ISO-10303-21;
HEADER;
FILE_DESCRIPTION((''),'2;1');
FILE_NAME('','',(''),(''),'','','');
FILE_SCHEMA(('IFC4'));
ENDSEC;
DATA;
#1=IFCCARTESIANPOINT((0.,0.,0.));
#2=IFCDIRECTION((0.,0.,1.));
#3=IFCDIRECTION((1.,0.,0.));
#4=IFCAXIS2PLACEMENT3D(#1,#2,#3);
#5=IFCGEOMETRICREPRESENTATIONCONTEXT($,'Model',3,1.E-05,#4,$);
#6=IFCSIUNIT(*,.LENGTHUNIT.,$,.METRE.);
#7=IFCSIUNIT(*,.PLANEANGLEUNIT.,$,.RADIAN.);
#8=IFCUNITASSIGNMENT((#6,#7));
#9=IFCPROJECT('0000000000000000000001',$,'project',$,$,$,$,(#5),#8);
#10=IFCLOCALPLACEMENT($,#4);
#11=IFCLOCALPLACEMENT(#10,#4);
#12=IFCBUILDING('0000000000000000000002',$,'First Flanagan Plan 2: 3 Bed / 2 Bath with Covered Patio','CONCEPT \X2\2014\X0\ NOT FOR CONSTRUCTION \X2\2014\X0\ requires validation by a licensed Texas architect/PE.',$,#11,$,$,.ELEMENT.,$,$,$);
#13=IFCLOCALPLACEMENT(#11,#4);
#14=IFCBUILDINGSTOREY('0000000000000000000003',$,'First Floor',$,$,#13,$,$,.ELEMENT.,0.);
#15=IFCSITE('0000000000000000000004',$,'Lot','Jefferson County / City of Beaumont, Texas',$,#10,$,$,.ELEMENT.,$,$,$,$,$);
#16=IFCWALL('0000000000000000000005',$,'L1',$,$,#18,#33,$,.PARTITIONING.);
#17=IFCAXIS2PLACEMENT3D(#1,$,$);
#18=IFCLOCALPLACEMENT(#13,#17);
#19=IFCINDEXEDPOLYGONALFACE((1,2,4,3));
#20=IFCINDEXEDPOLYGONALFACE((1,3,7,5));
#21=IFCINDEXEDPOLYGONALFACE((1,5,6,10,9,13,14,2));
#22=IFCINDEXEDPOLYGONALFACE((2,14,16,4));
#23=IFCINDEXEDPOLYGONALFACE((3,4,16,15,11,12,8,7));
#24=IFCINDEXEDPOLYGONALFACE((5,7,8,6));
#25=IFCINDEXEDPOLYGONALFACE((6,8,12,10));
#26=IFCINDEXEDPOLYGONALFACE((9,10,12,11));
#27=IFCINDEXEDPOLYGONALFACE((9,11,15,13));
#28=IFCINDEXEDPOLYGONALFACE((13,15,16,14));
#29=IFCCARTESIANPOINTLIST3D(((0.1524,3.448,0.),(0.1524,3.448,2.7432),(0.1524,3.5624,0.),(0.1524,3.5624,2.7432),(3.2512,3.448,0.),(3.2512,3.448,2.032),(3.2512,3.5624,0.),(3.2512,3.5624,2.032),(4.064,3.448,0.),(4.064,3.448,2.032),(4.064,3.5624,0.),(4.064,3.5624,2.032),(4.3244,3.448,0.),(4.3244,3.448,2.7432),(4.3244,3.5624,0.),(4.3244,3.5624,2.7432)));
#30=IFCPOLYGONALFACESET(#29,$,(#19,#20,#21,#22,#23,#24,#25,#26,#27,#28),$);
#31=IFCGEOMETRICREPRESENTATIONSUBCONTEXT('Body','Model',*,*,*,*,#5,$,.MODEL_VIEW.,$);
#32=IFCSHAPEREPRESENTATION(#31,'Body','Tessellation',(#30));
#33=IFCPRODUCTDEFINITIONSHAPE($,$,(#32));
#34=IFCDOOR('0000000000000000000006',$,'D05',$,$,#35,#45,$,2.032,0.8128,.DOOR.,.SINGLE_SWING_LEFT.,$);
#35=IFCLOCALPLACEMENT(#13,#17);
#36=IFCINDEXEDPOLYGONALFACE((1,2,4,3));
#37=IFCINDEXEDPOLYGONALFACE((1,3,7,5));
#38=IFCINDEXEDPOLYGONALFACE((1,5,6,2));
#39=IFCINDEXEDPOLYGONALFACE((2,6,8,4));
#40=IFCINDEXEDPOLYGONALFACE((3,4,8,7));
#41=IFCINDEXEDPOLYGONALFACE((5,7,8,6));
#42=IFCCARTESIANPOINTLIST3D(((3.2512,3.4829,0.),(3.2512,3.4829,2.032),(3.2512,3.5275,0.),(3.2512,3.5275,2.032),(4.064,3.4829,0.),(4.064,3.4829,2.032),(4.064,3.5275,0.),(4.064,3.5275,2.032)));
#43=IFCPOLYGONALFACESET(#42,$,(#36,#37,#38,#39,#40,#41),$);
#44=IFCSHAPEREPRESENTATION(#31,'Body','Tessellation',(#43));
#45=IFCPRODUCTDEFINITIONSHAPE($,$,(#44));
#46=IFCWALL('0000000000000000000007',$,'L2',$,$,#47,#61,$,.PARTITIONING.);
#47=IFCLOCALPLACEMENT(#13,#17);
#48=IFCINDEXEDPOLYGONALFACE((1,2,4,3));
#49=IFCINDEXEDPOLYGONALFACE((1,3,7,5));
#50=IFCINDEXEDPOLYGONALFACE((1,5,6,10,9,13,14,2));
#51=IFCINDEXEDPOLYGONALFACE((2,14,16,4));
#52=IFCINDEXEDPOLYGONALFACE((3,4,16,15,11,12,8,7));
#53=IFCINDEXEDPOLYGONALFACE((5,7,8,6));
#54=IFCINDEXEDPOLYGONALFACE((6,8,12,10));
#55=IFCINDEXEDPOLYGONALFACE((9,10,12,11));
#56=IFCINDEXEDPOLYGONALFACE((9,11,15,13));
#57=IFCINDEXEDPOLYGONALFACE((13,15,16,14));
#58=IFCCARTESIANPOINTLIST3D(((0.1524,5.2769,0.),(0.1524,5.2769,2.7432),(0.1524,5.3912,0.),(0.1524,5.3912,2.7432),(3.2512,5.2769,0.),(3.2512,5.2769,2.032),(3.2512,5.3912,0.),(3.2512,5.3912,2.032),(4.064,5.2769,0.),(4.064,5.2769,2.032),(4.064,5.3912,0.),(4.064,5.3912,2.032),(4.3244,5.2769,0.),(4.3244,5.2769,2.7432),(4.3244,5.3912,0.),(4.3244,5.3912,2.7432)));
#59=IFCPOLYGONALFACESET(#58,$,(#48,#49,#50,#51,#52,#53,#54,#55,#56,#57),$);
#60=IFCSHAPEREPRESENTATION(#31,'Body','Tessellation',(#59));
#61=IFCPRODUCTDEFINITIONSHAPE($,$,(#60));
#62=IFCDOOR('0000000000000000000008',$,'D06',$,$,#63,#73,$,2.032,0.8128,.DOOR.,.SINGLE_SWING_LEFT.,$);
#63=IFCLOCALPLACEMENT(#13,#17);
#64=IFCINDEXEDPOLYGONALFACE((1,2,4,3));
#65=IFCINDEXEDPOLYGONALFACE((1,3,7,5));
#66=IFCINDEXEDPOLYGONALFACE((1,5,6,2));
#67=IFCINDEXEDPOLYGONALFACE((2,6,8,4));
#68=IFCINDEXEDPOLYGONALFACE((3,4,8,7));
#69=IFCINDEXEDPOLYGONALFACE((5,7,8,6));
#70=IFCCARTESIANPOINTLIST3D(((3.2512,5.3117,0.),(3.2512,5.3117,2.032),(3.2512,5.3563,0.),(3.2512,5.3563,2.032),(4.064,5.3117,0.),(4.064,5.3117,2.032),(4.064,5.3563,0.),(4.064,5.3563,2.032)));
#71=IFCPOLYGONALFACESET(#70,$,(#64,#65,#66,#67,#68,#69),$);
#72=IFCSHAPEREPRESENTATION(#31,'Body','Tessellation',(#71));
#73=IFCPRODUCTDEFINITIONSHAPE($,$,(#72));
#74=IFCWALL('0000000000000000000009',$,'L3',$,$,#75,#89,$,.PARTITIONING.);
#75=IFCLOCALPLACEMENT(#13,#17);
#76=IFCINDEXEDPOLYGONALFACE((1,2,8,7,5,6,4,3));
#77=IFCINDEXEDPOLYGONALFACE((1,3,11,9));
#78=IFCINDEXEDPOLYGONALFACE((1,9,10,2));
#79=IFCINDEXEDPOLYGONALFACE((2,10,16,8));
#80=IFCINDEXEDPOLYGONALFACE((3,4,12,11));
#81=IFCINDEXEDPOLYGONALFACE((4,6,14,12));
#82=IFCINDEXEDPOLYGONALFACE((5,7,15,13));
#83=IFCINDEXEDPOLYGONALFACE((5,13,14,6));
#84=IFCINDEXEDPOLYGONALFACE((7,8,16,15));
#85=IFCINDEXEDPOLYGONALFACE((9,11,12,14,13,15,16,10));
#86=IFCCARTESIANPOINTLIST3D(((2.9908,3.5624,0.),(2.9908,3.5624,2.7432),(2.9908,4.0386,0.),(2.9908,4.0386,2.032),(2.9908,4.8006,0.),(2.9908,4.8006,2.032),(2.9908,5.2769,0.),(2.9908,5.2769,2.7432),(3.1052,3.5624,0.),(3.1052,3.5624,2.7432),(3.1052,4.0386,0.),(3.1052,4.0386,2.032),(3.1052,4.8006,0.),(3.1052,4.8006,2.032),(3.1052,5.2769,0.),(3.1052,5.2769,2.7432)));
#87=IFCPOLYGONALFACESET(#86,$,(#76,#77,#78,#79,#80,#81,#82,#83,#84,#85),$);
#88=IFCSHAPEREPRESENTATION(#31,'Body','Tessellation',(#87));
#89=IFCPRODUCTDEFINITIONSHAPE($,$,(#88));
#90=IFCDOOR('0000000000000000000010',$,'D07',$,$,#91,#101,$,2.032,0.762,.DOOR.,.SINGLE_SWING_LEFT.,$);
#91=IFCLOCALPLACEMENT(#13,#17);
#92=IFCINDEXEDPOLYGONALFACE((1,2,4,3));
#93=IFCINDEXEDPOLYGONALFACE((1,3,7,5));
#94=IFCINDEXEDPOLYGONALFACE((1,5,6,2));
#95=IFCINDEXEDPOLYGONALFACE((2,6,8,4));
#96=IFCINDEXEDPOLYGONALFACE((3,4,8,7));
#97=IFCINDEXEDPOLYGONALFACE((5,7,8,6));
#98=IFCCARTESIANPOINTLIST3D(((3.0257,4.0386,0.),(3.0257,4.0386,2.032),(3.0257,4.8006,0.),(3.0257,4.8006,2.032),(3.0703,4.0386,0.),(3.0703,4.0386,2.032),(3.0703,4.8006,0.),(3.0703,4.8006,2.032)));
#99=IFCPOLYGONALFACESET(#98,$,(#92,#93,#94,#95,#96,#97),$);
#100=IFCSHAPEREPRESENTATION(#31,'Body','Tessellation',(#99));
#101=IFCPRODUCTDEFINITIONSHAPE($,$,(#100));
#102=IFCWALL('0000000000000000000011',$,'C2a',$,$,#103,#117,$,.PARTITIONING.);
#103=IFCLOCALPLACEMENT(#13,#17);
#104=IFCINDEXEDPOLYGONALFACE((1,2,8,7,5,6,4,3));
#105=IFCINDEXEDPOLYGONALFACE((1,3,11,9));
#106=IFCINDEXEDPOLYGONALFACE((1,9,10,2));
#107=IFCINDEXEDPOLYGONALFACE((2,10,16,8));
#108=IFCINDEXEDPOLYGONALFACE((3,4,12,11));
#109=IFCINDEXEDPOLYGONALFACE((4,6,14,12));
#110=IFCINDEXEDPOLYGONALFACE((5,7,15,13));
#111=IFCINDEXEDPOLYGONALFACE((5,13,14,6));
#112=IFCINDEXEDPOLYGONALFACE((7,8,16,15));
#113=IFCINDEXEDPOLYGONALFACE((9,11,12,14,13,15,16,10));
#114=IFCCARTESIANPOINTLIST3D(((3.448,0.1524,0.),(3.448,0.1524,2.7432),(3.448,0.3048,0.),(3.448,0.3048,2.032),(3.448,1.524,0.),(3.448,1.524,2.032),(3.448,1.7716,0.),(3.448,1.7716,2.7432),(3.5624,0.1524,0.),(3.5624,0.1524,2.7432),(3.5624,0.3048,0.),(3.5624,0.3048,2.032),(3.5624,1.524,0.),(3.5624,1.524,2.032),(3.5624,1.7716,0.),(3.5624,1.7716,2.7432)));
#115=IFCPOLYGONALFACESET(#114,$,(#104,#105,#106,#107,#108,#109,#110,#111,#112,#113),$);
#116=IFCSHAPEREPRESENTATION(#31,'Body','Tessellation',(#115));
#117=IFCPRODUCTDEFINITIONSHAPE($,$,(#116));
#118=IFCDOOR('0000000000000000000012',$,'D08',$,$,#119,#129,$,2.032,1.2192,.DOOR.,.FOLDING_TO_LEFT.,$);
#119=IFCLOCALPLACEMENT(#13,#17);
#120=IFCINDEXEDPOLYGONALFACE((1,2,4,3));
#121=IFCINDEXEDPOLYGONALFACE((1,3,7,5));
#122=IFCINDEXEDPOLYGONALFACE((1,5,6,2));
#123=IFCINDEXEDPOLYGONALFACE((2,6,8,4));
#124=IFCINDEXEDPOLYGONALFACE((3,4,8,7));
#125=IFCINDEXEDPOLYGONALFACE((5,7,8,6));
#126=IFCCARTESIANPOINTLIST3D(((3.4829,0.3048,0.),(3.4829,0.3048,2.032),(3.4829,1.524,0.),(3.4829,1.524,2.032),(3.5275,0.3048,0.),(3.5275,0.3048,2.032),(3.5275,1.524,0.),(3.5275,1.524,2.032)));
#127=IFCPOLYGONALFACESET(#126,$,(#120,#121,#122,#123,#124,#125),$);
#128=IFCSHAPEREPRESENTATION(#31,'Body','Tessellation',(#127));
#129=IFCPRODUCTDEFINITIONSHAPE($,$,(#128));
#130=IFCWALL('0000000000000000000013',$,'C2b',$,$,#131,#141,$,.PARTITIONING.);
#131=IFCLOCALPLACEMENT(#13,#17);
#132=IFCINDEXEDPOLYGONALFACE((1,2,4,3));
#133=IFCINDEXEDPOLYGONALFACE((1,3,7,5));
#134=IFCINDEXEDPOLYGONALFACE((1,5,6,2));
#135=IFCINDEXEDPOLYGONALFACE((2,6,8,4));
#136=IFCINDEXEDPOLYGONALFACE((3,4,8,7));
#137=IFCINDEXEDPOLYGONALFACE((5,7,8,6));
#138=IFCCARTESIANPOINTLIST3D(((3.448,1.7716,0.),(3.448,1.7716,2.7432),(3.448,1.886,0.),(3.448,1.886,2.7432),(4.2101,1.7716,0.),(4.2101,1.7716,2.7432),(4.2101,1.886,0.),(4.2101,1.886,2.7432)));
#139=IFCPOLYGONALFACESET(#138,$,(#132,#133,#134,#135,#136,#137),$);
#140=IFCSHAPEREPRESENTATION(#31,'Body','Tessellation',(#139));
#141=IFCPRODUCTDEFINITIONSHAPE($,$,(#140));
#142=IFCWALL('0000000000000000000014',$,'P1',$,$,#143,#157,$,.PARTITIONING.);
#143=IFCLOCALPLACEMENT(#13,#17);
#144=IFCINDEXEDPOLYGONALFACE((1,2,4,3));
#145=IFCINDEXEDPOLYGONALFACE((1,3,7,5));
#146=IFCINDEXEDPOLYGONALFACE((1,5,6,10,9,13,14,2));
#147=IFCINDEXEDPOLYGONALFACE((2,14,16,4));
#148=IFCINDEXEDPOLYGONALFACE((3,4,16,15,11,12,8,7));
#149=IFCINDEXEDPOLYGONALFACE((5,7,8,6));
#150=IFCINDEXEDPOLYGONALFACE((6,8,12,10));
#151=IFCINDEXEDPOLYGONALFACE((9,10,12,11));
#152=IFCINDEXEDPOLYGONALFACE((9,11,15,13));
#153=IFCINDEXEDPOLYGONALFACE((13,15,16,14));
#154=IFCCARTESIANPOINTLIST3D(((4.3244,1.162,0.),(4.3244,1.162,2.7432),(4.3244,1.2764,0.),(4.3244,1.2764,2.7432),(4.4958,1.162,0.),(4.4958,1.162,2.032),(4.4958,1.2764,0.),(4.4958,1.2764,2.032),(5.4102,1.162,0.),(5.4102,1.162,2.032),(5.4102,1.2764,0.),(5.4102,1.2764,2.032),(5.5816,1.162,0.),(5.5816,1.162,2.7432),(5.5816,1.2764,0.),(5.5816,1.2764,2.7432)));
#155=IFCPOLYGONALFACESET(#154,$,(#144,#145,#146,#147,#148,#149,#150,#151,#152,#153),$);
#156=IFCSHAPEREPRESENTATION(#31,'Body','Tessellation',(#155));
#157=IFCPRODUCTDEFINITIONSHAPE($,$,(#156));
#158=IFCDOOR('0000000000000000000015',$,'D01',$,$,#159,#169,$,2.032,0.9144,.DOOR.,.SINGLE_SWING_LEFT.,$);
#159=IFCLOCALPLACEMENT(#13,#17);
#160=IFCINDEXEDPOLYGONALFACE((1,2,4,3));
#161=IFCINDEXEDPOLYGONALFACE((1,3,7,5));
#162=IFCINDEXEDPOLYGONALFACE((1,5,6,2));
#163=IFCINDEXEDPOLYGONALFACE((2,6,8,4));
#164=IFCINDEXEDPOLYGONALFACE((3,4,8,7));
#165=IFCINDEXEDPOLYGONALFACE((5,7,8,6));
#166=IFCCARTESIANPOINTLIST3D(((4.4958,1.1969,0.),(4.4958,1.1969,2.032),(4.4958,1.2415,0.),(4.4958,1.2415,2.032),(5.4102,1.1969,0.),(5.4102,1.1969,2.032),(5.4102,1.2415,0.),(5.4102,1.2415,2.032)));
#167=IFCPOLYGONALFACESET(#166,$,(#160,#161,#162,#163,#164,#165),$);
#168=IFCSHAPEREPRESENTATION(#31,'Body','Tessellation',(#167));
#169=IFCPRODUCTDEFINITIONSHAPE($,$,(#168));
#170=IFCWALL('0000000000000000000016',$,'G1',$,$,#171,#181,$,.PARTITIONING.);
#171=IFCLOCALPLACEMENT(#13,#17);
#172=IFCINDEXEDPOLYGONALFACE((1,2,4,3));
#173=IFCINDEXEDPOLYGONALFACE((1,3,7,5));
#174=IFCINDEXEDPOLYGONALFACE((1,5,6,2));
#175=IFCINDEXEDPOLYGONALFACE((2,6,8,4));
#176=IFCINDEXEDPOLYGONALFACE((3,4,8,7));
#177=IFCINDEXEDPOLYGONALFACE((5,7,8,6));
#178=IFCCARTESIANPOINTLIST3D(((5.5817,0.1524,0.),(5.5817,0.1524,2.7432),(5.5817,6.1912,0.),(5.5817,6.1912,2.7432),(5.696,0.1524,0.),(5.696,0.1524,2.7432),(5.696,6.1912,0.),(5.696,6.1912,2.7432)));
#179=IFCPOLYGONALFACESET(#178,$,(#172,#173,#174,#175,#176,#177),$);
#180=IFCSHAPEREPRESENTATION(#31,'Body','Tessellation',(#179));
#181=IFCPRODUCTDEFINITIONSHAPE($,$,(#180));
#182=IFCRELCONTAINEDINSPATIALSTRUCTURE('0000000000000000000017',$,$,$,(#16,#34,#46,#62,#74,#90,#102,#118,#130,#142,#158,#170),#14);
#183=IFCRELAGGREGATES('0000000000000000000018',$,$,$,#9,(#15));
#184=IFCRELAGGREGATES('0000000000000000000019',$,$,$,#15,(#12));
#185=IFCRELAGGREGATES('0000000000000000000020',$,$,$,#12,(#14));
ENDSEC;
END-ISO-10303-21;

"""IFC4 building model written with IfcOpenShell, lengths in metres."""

from ifc_helpers import new_model, si_unit, frame, frame_2d, origin_with_axes, place, context, subcontext, project, spatial, rectangle, extrude, element, fill, save


model = new_model("IFC4")

# Units and contexts
model_context = context("Model", 3, precision=1e-05, world=origin_with_axes())
body_context = subcontext(model_context, "Body", "Model", "MODEL_VIEW")
ifc_project = project(units=[si_unit("LENGTHUNIT", "METRE"), si_unit("PLANEANGLEUNIT", "RADIAN")], contexts=[model_context])

# Site, building, storey
site_placement = place(None, origin_with_axes())
site = spatial("IfcSite", under=ifc_project, at=site_placement, Name="Lot", Description="Jefferson County / City of Beaumont, Texas", CompositionType="ELEMENT")
building_placement = place(site_placement, origin_with_axes())
building = spatial("IfcBuilding", under=site, at=building_placement, Name="First Flanagan Plan 2: 3 Bed / 2 Bath with Covered Patio", Description="CONCEPT — NOT FOR CONSTRUCTION — requires validation by a licensed Texas architect/PE.", CompositionType="ELEMENT")
storey_placement = place(building_placement, origin_with_axes())
storey = spatial("IfcBuildingStorey", under=building, at=storey_placement, Name="First Floor", CompositionType="ELEMENT", Elevation=0.0)

# Walls, openings, doors
wall_1_placement = place(storey_placement, frame((0.1524, 3.5052, 0.0), z_axis=(0.0, 0.0, 1.0), x_axis=(1.0, 0.0, 0.0)))
wall_1 = element("IfcWall", 1, at=wall_1_placement, inside=storey, Name="L1", PredefinedType="PARTITIONING", context=body_context, shape_type="SweptSolid", body=[
    extrude(rectangle(XDim=4.1719, YDim=0.1143, at=frame_2d((2.086, 0.0), x_axis=(1.0, 0.0))), origin_with_axes(), (0.0, 0.0, 1.0), 2.7432),
])
opening_1_placement = place(wall_1_placement, frame((3.0988, 0.0, 0.0), z_axis=(0.0, 0.0, 1.0), x_axis=(1.0, 0.0, 0.0)))
opening_1 = element("IfcOpeningElement", 2, at=opening_1_placement, cuts=wall_1, PredefinedType="OPENING", context=body_context, shape_type="SweptSolid", body=[
    extrude(rectangle(XDim=0.8128, YDim=0.1448, at=frame_2d((0.4064, 0.0), x_axis=(1.0, 0.0))), origin_with_axes(), (0.0, 0.0, 1.0), 2.032),
])
door_1_placement = place(opening_1_placement, origin_with_axes())
door_1 = element("IfcDoor", 3, at=door_1_placement, inside=storey, Name="D05", OperationType="SINGLE_SWING_LEFT", OverallHeight=2.032, OverallWidth=0.8128, PredefinedType="DOOR", context=body_context, shape_type="SweptSolid", body=[
    extrude(rectangle(XDim=0.8128, YDim=0.0445, at=frame_2d((0.4064, 0.0), x_axis=(1.0, 0.0))), origin_with_axes(), (0.0, 0.0, 1.0), 2.032),
])
fill(opening_1, door_1)
wall_2_placement = place(storey_placement, frame((0.1524, 5.334, 0.0), z_axis=(0.0, 0.0, 1.0), x_axis=(1.0, 0.0, 0.0)))
wall_2 = element("IfcWall", 4, at=wall_2_placement, inside=storey, Name="L2", PredefinedType="PARTITIONING", context=body_context, shape_type="SweptSolid", body=[
    extrude(rectangle(XDim=4.1719, YDim=0.1143, at=frame_2d((2.086, 0.0), x_axis=(1.0, 0.0))), origin_with_axes(), (0.0, 0.0, 1.0), 2.7432),
])
opening_2_placement = place(wall_2_placement, frame((3.0988, 0.0, 0.0), z_axis=(0.0, 0.0, 1.0), x_axis=(1.0, 0.0, 0.0)))
opening_2 = element("IfcOpeningElement", 5, at=opening_2_placement, cuts=wall_2, PredefinedType="OPENING", context=body_context, shape_type="SweptSolid", body=[
    extrude(rectangle(XDim=0.8128, YDim=0.1448, at=frame_2d((0.4064, 0.0), x_axis=(1.0, 0.0))), origin_with_axes(), (0.0, 0.0, 1.0), 2.032),
])
door_2_placement = place(opening_2_placement, origin_with_axes())
door_2 = element("IfcDoor", 6, at=door_2_placement, inside=storey, Name="D06", OperationType="SINGLE_SWING_LEFT", OverallHeight=2.032, OverallWidth=0.8128, PredefinedType="DOOR", context=body_context, shape_type="SweptSolid", body=[
    extrude(rectangle(XDim=0.8128, YDim=0.0445, at=frame_2d((0.4064, 0.0), x_axis=(1.0, 0.0))), origin_with_axes(), (0.0, 0.0, 1.0), 2.032),
])
fill(opening_2, door_2)
wall_3_placement = place(storey_placement, frame((3.048, 3.5624, 0.0), z_axis=(0.0, 0.0, 1.0), x_axis=(0.0, 1.0, 0.0)))
wall_3 = element("IfcWall", 7, at=wall_3_placement, inside=storey, Name="L3", PredefinedType="PARTITIONING", context=body_context, shape_type="SweptSolid", body=[
    extrude(rectangle(XDim=1.7145, YDim=0.1143, at=frame_2d((0.8573, 0.0), x_axis=(1.0, 0.0))), origin_with_axes(), (0.0, 0.0, 1.0), 2.7432),
])
opening_3_placement = place(wall_3_placement, frame((0.4763, 0.0, 0.0), z_axis=(0.0, 0.0, 1.0), x_axis=(1.0, 0.0, 0.0)))
opening_3 = element("IfcOpeningElement", 8, at=opening_3_placement, cuts=wall_3, PredefinedType="OPENING", context=body_context, shape_type="SweptSolid", body=[
    extrude(rectangle(XDim=0.762, YDim=0.1448, at=frame_2d((0.381, 0.0), x_axis=(1.0, 0.0))), origin_with_axes(), (0.0, 0.0, 1.0), 2.032),
])
door_3_placement = place(opening_3_placement, origin_with_axes())
door_3 = element("IfcDoor", 9, at=door_3_placement, inside=storey, Name="D07", OperationType="SINGLE_SWING_LEFT", OverallHeight=2.032, OverallWidth=0.762, PredefinedType="DOOR", context=body_context, shape_type="SweptSolid", body=[
    extrude(rectangle(XDim=0.762, YDim=0.0445, at=frame_2d((0.381, 0.0), x_axis=(1.0, 0.0))), origin_with_axes(), (0.0, 0.0, 1.0), 2.032),
])
fill(opening_3, door_3)
wall_4_placement = place(storey_placement, frame((3.5052, 0.1524, 0.0), z_axis=(0.0, 0.0, 1.0), x_axis=(0.0, 1.0, 0.0)))
wall_4 = element("IfcWall", 10, at=wall_4_placement, inside=storey, Name="C2a", PredefinedType="PARTITIONING", context=body_context, shape_type="SweptSolid", body=[
    extrude(rectangle(XDim=1.6193, YDim=0.1143, at=frame_2d((0.8096, 0.0), x_axis=(1.0, 0.0))), origin_with_axes(), (0.0, 0.0, 1.0), 2.7432),
])
opening_4_placement = place(wall_4_placement, frame((0.1524, 0.0, 0.0), z_axis=(0.0, 0.0, 1.0), x_axis=(1.0, 0.0, 0.0)))
opening_4 = element("IfcOpeningElement", 11, at=opening_4_placement, cuts=wall_4, PredefinedType="OPENING", context=body_context, shape_type="SweptSolid", body=[
    extrude(rectangle(XDim=1.2192, YDim=0.1448, at=frame_2d((0.6096, 0.0), x_axis=(1.0, 0.0))), origin_with_axes(), (0.0, 0.0, 1.0), 2.032),
])
door_4_placement = place(opening_4_placement, origin_with_axes())
door_4 = element("IfcDoor", 12, at=door_4_placement, inside=storey, Name="D08", OperationType="FOLDING_TO_LEFT", OverallHeight=2.032, OverallWidth=1.2192, PredefinedType="DOOR", context=body_context, shape_type="SweptSolid", body=[
    extrude(rectangle(XDim=1.2192, YDim=0.0445, at=frame_2d((0.6096, 0.0), x_axis=(1.0, 0.0))), origin_with_axes(), (0.0, 0.0, 1.0), 2.032),
])
fill(opening_4, door_4)

# Wall
wall_5_placement = place(storey_placement, frame((3.4481, 1.8288, 0.0), z_axis=(0.0, 0.0, 1.0), x_axis=(1.0, 0.0, 0.0)))
element("IfcWall", 13, at=wall_5_placement, inside=storey, Name="C2b", PredefinedType="PARTITIONING", context=body_context, shape_type="SweptSolid", body=[
    extrude(rectangle(XDim=0.762, YDim=0.1143, at=frame_2d((0.381, 0.0), x_axis=(1.0, 0.0))), origin_with_axes(), (0.0, 0.0, 1.0), 2.7432),
])

# Wall, opening, door
wall_6_placement = place(storey_placement, frame((4.3243, 1.2192, 0.0), z_axis=(0.0, 0.0, 1.0), x_axis=(1.0, 0.0, 0.0)))
wall_6 = element("IfcWall", 14, at=wall_6_placement, inside=storey, Name="P1", PredefinedType="PARTITIONING", context=body_context, shape_type="SweptSolid", body=[
    extrude(rectangle(XDim=1.2573, YDim=0.1143, at=frame_2d((0.6287, 0.0), x_axis=(1.0, 0.0))), origin_with_axes(), (0.0, 0.0, 1.0), 2.7432),
])
opening_5_placement = place(wall_6_placement, frame((0.1715, 0.0, 0.0), z_axis=(0.0, 0.0, 1.0), x_axis=(1.0, 0.0, 0.0)))
opening_5 = element("IfcOpeningElement", 15, at=opening_5_placement, cuts=wall_6, PredefinedType="OPENING", context=body_context, shape_type="SweptSolid", body=[
    extrude(rectangle(XDim=0.9144, YDim=0.1448, at=frame_2d((0.4572, 0.0), x_axis=(1.0, 0.0))), origin_with_axes(), (0.0, 0.0, 1.0), 2.032),
])
door_5_placement = place(opening_5_placement, origin_with_axes())
door_5 = element("IfcDoor", 16, at=door_5_placement, inside=storey, Name="D01", OperationType="SINGLE_SWING_LEFT", OverallHeight=2.032, OverallWidth=0.9144, PredefinedType="DOOR", context=body_context, shape_type="SweptSolid", body=[
    extrude(rectangle(XDim=0.9144, YDim=0.0445, at=frame_2d((0.4572, 0.0), x_axis=(1.0, 0.0))), origin_with_axes(), (0.0, 0.0, 1.0), 2.032),
])
fill(opening_5, door_5)

# Wall
wall_7_placement = place(storey_placement, frame((5.6388, 0.1524, 0.0), z_axis=(0.0, 0.0, 1.0), x_axis=(0.0, 1.0, 0.0)))
element("IfcWall", 17, at=wall_7_placement, inside=storey, Name="G1", PredefinedType="PARTITIONING", context=body_context, shape_type="SweptSolid", body=[
    extrude(rectangle(XDim=6.0389, YDim=0.1143, at=frame_2d((3.0194, 0.0), x_axis=(1.0, 0.0))), origin_with_axes(), (0.0, 0.0, 1.0), 2.7432),
])

save(model, "model.ifc")
